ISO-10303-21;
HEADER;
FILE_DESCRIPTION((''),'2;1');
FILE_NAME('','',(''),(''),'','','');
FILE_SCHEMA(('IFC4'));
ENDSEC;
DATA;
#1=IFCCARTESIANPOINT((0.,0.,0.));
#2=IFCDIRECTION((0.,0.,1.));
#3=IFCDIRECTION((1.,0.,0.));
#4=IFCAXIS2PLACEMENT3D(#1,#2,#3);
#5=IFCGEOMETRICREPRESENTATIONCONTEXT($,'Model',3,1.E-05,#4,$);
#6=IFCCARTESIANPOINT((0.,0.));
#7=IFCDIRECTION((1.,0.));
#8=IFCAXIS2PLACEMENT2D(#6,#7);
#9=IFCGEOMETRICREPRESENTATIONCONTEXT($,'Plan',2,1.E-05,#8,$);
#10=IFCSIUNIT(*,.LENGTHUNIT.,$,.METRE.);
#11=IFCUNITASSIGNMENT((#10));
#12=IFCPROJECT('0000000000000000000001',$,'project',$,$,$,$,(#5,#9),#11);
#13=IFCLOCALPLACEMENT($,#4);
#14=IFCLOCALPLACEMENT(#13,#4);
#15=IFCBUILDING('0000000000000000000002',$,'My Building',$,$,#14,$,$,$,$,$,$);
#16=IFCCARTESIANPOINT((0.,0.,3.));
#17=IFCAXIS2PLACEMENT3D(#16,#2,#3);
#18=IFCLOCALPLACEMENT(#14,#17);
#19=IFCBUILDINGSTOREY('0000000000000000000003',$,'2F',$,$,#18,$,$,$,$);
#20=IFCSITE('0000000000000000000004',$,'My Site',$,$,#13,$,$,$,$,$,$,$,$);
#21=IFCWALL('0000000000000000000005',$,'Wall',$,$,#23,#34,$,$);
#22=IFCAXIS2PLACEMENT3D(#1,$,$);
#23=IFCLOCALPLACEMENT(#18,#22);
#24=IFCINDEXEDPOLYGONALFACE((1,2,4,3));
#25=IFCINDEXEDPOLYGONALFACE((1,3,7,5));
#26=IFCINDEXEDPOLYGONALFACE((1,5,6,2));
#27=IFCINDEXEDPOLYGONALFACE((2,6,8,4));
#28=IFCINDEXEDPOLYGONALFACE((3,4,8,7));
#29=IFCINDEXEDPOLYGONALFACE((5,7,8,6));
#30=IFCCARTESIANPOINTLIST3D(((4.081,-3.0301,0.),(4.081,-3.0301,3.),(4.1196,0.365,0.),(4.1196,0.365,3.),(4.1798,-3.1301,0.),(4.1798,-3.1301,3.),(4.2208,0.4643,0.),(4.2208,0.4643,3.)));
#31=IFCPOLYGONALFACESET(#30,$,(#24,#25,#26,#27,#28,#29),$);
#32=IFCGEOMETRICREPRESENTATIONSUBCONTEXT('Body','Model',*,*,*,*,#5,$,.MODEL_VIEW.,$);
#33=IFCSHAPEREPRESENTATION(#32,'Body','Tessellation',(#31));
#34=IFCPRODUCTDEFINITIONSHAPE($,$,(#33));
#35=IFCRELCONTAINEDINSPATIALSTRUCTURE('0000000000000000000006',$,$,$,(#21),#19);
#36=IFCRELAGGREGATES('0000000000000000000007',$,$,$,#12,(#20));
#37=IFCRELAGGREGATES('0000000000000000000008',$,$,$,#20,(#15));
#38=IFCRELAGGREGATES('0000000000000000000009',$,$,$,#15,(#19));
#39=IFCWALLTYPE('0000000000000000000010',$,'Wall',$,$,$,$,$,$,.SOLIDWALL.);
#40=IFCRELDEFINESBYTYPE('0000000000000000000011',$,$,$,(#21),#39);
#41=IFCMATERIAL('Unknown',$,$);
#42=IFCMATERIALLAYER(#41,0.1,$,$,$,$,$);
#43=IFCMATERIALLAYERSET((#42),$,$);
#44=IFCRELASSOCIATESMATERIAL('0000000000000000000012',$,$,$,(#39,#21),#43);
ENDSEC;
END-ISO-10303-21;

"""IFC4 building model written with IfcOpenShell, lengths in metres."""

from ifc_helpers import new_model, si_unit, frame, origin_with_axes, origin_2d_with_axis, place, context, subcontext, project, spatial, line, indexed_curve, outline, extrude, material, layer, layer_set, layer_usage, type_object, element, save


model = new_model("IFC4")

# Units and contexts
model_context = context("Model", 3, precision=1e-05, world=origin_with_axes())
plan_context = context("Plan", 2, precision=1e-05, world=origin_2d_with_axis())
body_context_1 = subcontext(model_context, "Body", "Model", "MODEL_VIEW")
ifc_project = project(units=[si_unit("LENGTHUNIT", "METRE")], contexts=[model_context, plan_context])

# Site, building, storey
site_placement = place(None, origin_with_axes())
site = spatial("IfcSite", under=ifc_project, at=site_placement, Name="My Site")
building_placement = place(site_placement, origin_with_axes())
building = spatial("IfcBuilding", under=site, at=building_placement, Name="My Building")
storey_placement = place(building_placement, frame((0.0, 0.0, 3.0), z_axis=(0.0, 0.0, 1.0), x_axis=(1.0, 0.0, 0.0)))
storey = spatial("IfcBuildingStorey", under=building, at=storey_placement, Name="2F")

# Shared definitions
ifc_material = material(Name="Unknown")
ifc_layer = layer(ifc_material, 0.1)
ifc_layer_set = layer_set([ifc_layer])
wall_type = type_object("IfcWallType", Name="Wall", PredefinedType="SOLIDWALL", material=ifc_layer_set)

# Wall
ifc_layer_usage_1 = layer_usage(ifc_layer_set, "AXIS2", "POSITIVE", 0.0)
wall_1_placement = place(storey_placement, frame((4.1196, 0.365, 0.0), z_axis=(0.0, 0.0, 1.0), x_axis=(-0.011386, -0.999935, 0.0)))
element("IfcWall", 1, at=wall_1_placement, inside=storey, type_object=wall_type, material=ifc_layer_usage_1, Name="Wall", context=body_context_1, shape_type="SweptSolid", body=[
    extrude(outline(indexed_curve([(0.0, 0.0), (-0.1004, 0.1), (3.4942, 0.1), (3.3954, 0.0)], segments=[line(1, 2, 3, 4, 1)])), origin_with_axes(), (0.0, 0.0, 1.0), 3.0),
])

save(model, "model.ifc")
